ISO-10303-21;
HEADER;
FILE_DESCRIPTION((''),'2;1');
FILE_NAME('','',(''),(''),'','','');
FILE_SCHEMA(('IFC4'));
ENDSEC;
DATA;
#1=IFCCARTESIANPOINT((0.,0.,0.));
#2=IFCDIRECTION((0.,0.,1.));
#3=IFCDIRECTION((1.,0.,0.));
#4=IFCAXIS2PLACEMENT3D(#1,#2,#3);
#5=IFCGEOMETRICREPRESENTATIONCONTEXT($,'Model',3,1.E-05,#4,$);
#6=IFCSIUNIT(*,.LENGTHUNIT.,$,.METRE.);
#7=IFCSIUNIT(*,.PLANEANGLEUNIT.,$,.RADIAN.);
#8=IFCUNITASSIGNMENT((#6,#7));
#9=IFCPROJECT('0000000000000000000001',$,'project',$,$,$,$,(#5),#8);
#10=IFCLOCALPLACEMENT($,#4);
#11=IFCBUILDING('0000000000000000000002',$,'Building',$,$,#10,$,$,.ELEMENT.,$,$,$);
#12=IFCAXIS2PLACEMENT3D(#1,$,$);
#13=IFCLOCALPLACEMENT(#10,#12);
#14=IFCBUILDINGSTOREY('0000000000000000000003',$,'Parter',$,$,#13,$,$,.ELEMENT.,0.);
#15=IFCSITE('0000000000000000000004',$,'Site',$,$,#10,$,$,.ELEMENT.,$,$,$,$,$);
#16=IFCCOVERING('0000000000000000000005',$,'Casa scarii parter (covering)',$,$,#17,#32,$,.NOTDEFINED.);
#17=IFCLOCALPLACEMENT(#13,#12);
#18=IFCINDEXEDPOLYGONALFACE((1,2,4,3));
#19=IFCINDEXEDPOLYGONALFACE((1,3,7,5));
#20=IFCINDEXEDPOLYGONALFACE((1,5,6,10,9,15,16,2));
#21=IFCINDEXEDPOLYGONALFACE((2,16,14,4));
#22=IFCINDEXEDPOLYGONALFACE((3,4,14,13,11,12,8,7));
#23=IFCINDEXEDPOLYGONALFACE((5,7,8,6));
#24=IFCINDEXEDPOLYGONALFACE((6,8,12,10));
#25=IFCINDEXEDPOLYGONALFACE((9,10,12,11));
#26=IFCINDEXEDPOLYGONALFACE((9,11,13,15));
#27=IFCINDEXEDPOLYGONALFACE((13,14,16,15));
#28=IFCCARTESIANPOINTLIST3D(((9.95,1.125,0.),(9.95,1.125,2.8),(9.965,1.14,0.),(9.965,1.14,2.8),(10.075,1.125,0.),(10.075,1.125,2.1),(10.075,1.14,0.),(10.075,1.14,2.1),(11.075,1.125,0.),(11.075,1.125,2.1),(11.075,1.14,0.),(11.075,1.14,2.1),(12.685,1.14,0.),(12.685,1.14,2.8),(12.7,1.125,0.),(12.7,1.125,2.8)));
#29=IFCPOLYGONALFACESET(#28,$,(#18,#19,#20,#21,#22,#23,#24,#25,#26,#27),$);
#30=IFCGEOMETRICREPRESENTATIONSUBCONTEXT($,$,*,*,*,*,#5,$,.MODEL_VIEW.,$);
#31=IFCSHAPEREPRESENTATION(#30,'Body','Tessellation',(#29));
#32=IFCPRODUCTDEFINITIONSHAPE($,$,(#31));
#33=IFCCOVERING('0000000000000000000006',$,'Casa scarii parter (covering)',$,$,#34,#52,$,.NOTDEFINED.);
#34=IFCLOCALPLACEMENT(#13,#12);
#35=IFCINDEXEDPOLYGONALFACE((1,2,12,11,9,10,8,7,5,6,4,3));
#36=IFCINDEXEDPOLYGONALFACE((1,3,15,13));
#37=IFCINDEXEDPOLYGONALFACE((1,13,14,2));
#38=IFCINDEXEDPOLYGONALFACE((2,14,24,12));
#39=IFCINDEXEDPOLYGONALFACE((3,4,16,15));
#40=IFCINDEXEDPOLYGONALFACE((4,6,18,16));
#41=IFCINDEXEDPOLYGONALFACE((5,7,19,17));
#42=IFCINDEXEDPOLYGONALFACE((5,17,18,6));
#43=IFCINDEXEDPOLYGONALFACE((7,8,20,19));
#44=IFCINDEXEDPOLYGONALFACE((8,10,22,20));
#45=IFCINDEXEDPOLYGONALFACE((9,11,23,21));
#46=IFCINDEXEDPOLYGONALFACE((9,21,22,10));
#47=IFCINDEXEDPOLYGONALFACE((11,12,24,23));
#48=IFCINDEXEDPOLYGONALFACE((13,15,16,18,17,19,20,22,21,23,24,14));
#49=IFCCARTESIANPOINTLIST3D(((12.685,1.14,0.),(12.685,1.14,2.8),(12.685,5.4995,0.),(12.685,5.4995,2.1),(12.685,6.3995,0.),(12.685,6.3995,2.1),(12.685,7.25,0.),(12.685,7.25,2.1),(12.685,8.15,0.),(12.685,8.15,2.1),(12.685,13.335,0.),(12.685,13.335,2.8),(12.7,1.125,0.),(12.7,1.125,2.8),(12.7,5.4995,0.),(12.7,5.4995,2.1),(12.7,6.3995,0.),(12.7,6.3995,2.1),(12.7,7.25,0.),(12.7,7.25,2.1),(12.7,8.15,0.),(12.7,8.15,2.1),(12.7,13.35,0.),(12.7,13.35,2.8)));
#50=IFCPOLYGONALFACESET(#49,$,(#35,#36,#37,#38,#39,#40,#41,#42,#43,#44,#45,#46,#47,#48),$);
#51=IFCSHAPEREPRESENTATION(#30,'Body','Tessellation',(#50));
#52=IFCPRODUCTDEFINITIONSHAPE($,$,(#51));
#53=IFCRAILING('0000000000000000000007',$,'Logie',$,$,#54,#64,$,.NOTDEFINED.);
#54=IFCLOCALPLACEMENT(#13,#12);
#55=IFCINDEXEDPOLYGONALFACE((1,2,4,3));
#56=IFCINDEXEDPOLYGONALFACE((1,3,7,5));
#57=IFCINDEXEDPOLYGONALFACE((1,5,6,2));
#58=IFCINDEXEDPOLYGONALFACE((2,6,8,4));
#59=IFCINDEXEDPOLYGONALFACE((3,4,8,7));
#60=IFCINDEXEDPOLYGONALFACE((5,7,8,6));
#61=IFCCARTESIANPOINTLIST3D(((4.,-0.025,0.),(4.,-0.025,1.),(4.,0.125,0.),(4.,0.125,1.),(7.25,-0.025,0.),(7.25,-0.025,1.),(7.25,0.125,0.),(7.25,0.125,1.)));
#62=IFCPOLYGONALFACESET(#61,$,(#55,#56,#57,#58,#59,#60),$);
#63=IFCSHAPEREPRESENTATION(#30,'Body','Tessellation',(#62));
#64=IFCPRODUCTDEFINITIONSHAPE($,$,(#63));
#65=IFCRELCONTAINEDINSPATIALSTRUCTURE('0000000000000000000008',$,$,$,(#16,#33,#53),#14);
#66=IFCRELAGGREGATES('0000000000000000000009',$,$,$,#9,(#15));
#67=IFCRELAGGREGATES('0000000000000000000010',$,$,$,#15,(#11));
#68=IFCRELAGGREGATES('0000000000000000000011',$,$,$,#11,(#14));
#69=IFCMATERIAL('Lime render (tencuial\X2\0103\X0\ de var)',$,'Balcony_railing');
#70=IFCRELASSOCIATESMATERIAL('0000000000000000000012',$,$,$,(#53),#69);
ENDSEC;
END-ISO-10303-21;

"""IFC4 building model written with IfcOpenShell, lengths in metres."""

from ifc_helpers import new_model, si_unit, frame, origin, origin_with_axes, origin_2d, place, context, subcontext, project, spatial, polyline, rectangle, outline, extrude, material, element, save


model = new_model("IFC4")

# Units and contexts
model_context = context("Model", 3, precision=1e-05, world=origin_with_axes())
sub_context = subcontext(model_context, None, None, "MODEL_VIEW")
ifc_project = project(units=[si_unit("LENGTHUNIT", "METRE"), si_unit("PLANEANGLEUNIT", "RADIAN")], contexts=[model_context])

# Site, building, storey
placement = place(None, origin_with_axes())
site = spatial("IfcSite", under=ifc_project, at=placement, Name="Site", CompositionType="ELEMENT")
building = spatial("IfcBuilding", under=site, at=placement, Name="Building", CompositionType="ELEMENT")
storey_placement = place(placement, origin())
storey = spatial("IfcBuildingStorey", under=building, at=storey_placement, Name="Parter", CompositionType="ELEMENT", Elevation=0.0)

# Covering, opening
covering_1_placement = place(storey_placement, origin_with_axes())
covering_1 = element("IfcCovering", 1, at=covering_1_placement, inside=storey, Name="Casa scarii parter (covering)", PredefinedType="NOTDEFINED", context=sub_context, shape_type="SweptSolid", body=[
    extrude(outline(polyline([(9.95, 1.125), (12.7, 1.125), (12.685, 1.14), (9.965, 1.14), (9.95, 1.125)])), origin(), (0.0, 0.0, 1.0), 2.8),
])
opening_1_placement = place(covering_1_placement, frame((10.575, 1.19, 0.0), z_axis=(0.0, -1.0, 0.0), x_axis=(1.0, 0.0, 0.0)))
element("IfcOpeningElement", 2, at=opening_1_placement, cuts=covering_1, PredefinedType="OPENING", context=sub_context, shape_type="SweptSolid", body=[
    extrude(rectangle(XDim=1.0, YDim=2.1, at=origin_2d()), frame((0.0, 1.05, 0.0)), (0.0, 0.0, 1.0), 0.38),
])

# Covering, openings
covering_2_placement = place(storey_placement, origin_with_axes())
covering_2 = element("IfcCovering", 3, at=covering_2_placement, inside=storey, Name="Casa scarii parter (covering)", PredefinedType="NOTDEFINED", context=sub_context, shape_type="SweptSolid", body=[
    extrude(outline(polyline([(12.7, 1.125), (12.7, 13.35), (12.685, 13.335), (12.685, 1.14), (12.7, 1.125)])), origin(), (0.0, 0.0, 1.0), 2.8),
])
opening_2_placement = place(covering_2_placement, frame((12.635, 5.9495, 0.0), z_axis=(1.0, 0.0, 0.0), x_axis=(0.0, 1.0, 0.0)))
element("IfcOpeningElement", 4, at=opening_2_placement, cuts=covering_2, PredefinedType="OPENING", context=sub_context, shape_type="SweptSolid", body=[
    extrude(rectangle(XDim=0.9, YDim=2.1, at=origin_2d()), frame((0.0, 1.05, 0.0)), (0.0, 0.0, 1.0), 0.38),
])
opening_3_placement = place(covering_2_placement, frame((12.635, 7.7, 0.0), z_axis=(1.0, 0.0, 0.0), x_axis=(0.0, 1.0, 0.0)))
element("IfcOpeningElement", 5, at=opening_3_placement, cuts=covering_2, PredefinedType="OPENING", context=sub_context, shape_type="SweptSolid", body=[
    extrude(rectangle(XDim=0.9, YDim=2.1, at=origin_2d()), frame((0.0, 1.05, 0.0)), (0.0, 0.0, 1.0), 0.38),
])

# Railing
ifc_material = material(Name="Lime render (tencuială de var)", Category="Balcony_railing")
railing_placement = place(storey_placement, frame((4.0, -0.025, 0.0), z_axis=(0.0, 0.0, 1.0), x_axis=(1.0, 0.0, 0.0)))
element("IfcRailing", 6, at=railing_placement, inside=storey, material=ifc_material, Name="Logie", PredefinedType="NOTDEFINED", context=sub_context, shape_type="SweptSolid", body=[
    extrude(outline(polyline([(0.0, 0.0), (3.25, 0.0), (3.25, 0.15), (0.0, 0.15), (0.0, 0.0)])), origin(), (0.0, 0.0, 1.0), 1.0),
])

save(model, "model.ifc")
